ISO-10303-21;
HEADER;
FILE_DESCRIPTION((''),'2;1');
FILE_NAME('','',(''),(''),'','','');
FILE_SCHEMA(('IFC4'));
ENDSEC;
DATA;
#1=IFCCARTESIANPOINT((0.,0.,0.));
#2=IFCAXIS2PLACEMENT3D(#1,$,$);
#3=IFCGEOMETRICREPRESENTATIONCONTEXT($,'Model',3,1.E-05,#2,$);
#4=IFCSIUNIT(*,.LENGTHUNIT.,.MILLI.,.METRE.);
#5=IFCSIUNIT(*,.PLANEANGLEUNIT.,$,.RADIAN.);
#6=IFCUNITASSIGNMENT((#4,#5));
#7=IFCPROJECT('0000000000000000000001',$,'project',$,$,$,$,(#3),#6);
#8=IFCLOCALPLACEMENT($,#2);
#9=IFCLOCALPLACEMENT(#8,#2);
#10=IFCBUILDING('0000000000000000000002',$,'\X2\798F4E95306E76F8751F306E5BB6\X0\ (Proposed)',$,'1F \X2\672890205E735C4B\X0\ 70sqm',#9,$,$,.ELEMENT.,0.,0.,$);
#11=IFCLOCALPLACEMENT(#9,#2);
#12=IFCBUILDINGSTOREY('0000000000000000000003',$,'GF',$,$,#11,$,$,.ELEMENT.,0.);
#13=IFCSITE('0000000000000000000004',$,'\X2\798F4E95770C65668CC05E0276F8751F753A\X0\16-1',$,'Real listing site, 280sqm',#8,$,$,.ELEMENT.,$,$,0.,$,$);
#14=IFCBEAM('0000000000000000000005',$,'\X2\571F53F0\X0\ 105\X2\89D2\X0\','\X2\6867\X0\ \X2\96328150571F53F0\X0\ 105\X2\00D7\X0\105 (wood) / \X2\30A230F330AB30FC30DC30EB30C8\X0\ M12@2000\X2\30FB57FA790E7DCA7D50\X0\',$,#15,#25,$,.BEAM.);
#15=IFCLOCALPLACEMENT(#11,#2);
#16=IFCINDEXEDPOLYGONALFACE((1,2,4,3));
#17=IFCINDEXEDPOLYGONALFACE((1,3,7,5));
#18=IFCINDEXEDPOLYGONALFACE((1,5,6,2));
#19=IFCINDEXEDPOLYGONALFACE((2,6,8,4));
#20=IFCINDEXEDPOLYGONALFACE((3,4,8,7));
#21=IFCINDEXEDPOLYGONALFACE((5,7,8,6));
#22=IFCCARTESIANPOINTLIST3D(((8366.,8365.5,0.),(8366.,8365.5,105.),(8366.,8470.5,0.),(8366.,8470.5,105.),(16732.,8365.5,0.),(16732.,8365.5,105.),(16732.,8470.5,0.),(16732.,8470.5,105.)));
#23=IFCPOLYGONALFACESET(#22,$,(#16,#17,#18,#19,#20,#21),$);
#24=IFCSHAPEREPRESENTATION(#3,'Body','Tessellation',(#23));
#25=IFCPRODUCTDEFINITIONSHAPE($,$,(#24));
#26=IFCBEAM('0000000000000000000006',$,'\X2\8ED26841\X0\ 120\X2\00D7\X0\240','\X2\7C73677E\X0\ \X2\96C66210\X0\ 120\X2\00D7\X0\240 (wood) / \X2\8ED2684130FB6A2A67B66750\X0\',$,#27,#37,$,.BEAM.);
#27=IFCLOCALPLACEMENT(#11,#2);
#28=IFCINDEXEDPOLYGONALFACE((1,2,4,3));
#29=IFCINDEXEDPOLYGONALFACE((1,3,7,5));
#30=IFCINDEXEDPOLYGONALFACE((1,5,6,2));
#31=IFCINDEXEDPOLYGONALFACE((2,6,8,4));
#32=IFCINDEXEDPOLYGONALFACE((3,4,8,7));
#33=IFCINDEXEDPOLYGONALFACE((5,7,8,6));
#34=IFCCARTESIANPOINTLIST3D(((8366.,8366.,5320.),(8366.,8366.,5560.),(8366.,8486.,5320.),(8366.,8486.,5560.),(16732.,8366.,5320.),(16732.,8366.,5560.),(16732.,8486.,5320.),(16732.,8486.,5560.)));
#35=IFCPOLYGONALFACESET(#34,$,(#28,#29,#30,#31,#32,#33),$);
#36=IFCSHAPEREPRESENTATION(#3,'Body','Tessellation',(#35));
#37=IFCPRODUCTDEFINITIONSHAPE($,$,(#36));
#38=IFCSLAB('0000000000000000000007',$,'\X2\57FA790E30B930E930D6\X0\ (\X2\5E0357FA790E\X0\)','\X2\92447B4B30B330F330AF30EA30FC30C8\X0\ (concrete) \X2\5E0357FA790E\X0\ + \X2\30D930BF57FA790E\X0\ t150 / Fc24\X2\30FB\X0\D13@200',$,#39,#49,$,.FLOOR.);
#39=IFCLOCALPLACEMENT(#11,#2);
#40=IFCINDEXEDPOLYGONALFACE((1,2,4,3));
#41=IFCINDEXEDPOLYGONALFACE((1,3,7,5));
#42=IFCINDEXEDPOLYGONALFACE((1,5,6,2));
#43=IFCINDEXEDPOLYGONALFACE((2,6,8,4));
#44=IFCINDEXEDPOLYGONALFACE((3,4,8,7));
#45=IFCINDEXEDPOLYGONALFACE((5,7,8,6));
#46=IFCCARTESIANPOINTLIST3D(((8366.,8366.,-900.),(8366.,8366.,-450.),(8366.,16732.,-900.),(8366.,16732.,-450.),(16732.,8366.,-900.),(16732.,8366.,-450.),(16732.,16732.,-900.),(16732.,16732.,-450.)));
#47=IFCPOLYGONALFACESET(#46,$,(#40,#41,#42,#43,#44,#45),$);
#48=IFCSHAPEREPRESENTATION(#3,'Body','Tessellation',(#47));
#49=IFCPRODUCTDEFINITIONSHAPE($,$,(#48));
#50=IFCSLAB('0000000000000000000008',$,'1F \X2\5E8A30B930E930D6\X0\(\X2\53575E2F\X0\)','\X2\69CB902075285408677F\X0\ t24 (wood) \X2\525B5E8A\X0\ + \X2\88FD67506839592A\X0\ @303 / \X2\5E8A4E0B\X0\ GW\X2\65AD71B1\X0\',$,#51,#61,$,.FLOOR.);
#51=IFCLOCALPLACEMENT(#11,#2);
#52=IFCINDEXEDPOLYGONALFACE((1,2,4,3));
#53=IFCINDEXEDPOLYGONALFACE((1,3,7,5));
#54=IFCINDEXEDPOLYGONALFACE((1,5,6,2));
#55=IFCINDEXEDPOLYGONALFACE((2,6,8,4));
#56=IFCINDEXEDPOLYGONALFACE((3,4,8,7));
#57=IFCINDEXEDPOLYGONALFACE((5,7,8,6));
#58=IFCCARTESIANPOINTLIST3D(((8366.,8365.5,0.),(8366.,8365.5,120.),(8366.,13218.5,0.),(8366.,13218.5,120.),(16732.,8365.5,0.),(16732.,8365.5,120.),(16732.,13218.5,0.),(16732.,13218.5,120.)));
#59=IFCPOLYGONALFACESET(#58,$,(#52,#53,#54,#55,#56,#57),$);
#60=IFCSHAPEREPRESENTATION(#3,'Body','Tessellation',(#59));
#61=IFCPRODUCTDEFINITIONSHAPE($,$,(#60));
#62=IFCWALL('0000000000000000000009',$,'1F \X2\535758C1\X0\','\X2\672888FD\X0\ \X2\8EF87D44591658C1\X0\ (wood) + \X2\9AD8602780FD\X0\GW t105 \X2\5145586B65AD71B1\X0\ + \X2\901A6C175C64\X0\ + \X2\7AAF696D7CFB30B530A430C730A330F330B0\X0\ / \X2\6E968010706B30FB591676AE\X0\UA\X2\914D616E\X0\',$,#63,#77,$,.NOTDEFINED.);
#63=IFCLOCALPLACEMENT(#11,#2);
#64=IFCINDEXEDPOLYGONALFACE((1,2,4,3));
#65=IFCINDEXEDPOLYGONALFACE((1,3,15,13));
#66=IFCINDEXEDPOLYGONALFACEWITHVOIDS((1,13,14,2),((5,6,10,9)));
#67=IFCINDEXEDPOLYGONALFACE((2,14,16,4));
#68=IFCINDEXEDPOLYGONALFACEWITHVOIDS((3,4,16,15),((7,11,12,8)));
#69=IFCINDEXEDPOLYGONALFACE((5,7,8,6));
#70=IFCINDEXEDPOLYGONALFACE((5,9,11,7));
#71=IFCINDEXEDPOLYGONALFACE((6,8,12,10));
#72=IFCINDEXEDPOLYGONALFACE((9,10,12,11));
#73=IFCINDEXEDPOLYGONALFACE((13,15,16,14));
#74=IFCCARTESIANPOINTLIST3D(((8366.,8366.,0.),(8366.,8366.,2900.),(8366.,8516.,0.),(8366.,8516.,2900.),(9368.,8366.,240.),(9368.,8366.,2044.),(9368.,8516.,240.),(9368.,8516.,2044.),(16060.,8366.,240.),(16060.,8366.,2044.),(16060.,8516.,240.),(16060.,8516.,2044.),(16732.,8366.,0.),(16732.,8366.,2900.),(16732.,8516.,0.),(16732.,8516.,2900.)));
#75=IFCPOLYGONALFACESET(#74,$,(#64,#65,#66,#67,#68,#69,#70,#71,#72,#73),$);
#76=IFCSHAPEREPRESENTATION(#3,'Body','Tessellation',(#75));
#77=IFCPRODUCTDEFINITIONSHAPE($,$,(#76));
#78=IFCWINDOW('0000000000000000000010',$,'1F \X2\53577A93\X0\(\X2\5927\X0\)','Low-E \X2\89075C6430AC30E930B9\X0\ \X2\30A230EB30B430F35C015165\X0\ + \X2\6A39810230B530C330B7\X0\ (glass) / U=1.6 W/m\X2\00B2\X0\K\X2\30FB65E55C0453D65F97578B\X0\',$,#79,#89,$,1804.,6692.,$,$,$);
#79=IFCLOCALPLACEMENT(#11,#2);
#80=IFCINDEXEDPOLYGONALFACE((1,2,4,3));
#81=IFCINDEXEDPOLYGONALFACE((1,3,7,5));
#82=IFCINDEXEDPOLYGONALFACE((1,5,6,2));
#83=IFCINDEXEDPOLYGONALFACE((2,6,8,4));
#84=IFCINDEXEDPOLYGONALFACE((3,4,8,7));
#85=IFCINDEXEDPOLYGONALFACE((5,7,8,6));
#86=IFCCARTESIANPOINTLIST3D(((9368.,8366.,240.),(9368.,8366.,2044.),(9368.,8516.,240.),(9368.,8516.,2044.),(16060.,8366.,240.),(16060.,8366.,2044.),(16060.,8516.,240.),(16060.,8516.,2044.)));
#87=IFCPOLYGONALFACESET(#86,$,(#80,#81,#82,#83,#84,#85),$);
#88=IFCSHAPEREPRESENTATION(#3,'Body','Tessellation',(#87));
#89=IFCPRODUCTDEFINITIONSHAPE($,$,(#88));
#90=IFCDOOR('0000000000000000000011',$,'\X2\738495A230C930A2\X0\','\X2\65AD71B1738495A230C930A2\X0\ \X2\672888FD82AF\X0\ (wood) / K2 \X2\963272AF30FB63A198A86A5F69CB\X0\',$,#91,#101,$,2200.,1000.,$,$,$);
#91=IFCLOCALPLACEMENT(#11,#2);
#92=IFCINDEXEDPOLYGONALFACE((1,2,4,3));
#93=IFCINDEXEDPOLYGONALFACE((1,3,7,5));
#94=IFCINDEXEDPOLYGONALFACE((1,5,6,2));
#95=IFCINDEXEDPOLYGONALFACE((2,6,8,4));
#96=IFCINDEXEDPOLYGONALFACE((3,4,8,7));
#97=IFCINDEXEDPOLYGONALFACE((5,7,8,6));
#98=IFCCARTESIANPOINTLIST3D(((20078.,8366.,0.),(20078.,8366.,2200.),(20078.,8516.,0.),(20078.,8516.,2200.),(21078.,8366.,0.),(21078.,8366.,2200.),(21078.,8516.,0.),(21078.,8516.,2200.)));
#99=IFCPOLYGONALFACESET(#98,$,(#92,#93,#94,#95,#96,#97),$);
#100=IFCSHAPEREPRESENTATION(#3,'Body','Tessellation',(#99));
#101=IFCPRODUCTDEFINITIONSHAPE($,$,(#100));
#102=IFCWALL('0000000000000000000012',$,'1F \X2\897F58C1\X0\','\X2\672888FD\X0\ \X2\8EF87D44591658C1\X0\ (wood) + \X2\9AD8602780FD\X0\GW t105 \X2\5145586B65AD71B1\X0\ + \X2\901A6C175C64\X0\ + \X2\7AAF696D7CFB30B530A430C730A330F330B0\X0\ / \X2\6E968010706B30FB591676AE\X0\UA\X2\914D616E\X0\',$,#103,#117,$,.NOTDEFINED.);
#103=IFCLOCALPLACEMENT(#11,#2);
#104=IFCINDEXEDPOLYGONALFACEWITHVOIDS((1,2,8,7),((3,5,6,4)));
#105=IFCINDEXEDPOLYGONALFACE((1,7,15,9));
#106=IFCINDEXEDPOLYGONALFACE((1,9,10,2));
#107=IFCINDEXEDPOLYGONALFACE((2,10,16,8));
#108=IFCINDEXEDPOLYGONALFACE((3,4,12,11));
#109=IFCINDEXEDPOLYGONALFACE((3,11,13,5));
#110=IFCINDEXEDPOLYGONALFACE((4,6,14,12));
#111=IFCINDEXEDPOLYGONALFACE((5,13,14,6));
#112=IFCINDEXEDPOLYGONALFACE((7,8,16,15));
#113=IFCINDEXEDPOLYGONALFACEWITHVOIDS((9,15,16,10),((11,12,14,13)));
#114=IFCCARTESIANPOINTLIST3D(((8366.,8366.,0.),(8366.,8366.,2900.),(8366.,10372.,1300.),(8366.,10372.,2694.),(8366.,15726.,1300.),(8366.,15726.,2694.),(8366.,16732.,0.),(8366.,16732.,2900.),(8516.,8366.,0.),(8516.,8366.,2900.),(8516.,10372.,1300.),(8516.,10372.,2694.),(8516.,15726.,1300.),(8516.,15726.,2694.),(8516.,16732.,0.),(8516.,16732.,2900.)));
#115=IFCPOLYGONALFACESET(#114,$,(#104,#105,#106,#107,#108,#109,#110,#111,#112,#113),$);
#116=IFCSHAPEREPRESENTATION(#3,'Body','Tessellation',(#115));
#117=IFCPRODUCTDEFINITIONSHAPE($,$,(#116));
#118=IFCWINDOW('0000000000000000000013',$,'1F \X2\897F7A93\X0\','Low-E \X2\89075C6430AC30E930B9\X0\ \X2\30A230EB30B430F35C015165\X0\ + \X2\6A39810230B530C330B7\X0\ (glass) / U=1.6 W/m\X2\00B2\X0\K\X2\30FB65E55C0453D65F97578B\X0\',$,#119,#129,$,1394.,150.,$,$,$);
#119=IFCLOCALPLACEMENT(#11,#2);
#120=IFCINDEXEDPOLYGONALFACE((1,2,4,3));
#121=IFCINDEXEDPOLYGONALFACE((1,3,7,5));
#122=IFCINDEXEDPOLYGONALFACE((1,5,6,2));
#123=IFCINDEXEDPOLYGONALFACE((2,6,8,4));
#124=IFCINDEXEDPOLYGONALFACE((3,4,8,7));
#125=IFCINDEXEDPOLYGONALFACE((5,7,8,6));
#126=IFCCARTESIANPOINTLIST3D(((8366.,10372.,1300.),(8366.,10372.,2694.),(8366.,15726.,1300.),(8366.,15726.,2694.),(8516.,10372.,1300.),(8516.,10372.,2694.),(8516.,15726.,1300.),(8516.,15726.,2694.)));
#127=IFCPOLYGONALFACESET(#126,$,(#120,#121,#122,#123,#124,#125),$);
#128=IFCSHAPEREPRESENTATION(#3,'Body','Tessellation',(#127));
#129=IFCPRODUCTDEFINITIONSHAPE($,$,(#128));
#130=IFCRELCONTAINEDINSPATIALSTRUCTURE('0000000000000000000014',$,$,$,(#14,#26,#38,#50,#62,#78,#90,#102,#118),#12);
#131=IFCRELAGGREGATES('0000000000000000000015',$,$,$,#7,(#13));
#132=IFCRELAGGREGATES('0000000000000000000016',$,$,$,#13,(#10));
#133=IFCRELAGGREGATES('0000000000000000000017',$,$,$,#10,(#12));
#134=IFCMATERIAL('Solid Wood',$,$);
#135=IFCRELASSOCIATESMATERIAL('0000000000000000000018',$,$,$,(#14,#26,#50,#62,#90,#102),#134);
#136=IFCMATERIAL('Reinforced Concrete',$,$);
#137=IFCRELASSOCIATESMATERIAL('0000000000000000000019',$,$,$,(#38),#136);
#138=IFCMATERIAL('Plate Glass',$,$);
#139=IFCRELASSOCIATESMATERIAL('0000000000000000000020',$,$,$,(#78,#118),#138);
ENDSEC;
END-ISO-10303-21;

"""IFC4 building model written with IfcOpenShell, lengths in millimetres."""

from ifc_helpers import new_model, si_unit, frame, frame_2d, origin, place, context, project, spatial, rectangle, extrude, material, element, fill, save


model = new_model("IFC4")

# Units and contexts
model_context = context("Model", 3, precision=1e-05, world=origin())
ifc_project = project(units=[si_unit("LENGTHUNIT", "METRE", prefix="MILLI"), si_unit("PLANEANGLEUNIT", "RADIAN")], contexts=[model_context])

# Site, building, storey
site_placement = place(None, origin())
site = spatial("IfcSite", under=ifc_project, at=site_placement, Name="福井県敦賀市相生町16-1", ObjectType="Real listing site, 280sqm", CompositionType="ELEMENT", RefElevation=0.0)
building_placement = place(site_placement, origin())
building = spatial("IfcBuilding", under=site, at=building_placement, Name="福井の相生の家 (Proposed)", ObjectType="1F 木造平屋 70sqm", CompositionType="ELEMENT", ElevationOfRefHeight=0.0, ElevationOfTerrain=0.0)
storey_placement = place(building_placement, origin())
storey = spatial("IfcBuildingStorey", under=building, at=storey_placement, Name="GF", CompositionType="ELEMENT", Elevation=0.0)

# Shared definitions
ifc_material_1 = material(Name="Solid Wood")

# Beams
beam_1_placement = place(storey_placement, frame((4183.0, 4183.0, 0.0)))
element("IfcBeam", 1, at=beam_1_placement, inside=storey, material=ifc_material_1, Name="土台 105角", Description="桧 防腐土台 105×105 (wood) / アンカーボルト M12@2000・基礎緊結", PredefinedType="BEAM", context=model_context, shape_type="SweptSolid", body=[
    extrude(rectangle(XDim=8366.0, YDim=105.0, at=frame_2d((4183.0, 52.0))), frame((4183.0, 4183.0, 0.0)), (0.0, 0.0, 1.0), 105.0),
])
beam_2_placement = place(storey_placement, frame((4183.0, 4183.0, 2660.0)))
element("IfcBeam", 2, at=beam_2_placement, inside=storey, material=ifc_material_1, Name="軒桁 120×240", Description="米松 集成 120×240 (wood) / 軒桁・横架材", PredefinedType="BEAM", context=model_context, shape_type="SweptSolid", body=[
    extrude(rectangle(XDim=8366.0, YDim=120.0, at=frame_2d((4183.0, 60.0))), frame((4183.0, 4183.0, 2660.0)), (0.0, 0.0, 1.0), 240.0),
])

# Slabs
ifc_material_2 = material(Name="Reinforced Concrete")
slab_1_placement = place(storey_placement, frame((4183.0, 4183.0, -450.0)))
element("IfcSlab", 3, at=slab_1_placement, inside=storey, material=ifc_material_2, Name="基礎スラブ (布基礎)", Description="鉄筋コンクリート (concrete) 布基礎 + ベタ基礎 t150 / Fc24・D13@200", PredefinedType="FLOOR", context=model_context, shape_type="SweptSolid", body=[
    extrude(rectangle(XDim=8366.0, YDim=8366.0, at=frame_2d((4183.0, 4183.0))), frame((4183.0, 4183.0, -450.0)), (0.0, 0.0, 1.0), 450.0),
])
slab_2_placement = place(storey_placement, frame((4183.0, 4183.0, 0.0)))
element("IfcSlab", 4, at=slab_2_placement, inside=storey, material=ifc_material_1, Name="1F 床スラブ(南帯)", Description="構造用合板 t24 (wood) 剛床 + 製材根太 @303 / 床下 GW断熱", PredefinedType="FLOOR", context=model_context, shape_type="SweptSolid", body=[
    extrude(rectangle(XDim=8366.0, YDim=4853.0, at=frame_2d((4183.0, 2426.0))), frame((4183.0, 4183.0, 0.0)), (0.0, 0.0, 1.0), 120.0),
])

# Wall, openings, window, door
wall_1_placement = place(storey_placement, frame((4183.0, 4183.0, 0.0)))
wall_1 = element("IfcWall", 5, at=wall_1_placement, inside=storey, material=ifc_material_1, Name="1F 南壁", Description="木製 軸組外壁 (wood) + 高性能GW t105 充填断熱 + 通気層 + 窯業系サイディング / 準耐火・外皮UA配慮", PredefinedType="NOTDEFINED", context=model_context, shape_type="SweptSolid", body=[
    extrude(rectangle(XDim=8366.0, YDim=150.0, at=frame_2d((4183.0, 75.0))), frame((4183.0, 4183.0, 0.0)), (0.0, 0.0, 1.0), 2900.0),
])
opening_1_placement = place(storey_placement, frame((4684.0, 4183.0, 120.0)))
opening_1 = element("IfcOpeningElement", 6, at=opening_1_placement, cuts=wall_1, PredefinedType="NOTDEFINED", context=model_context, shape_type="SweptSolid", body=[
    extrude(rectangle(XDim=6692.0, YDim=150.0, at=frame_2d((3346.0, 75.0))), frame((4684.0, 4183.0, 120.0)), (0.0, 0.0, 1.0), 1804.0),
])
opening_2_placement = place(storey_placement, frame((10039.0, 4183.0, 0.0)))
opening_2 = element("IfcOpeningElement", 7, at=opening_2_placement, cuts=wall_1, PredefinedType="NOTDEFINED", context=model_context, shape_type="SweptSolid", body=[
    extrude(rectangle(XDim=1000.0, YDim=150.0, at=frame_2d((500.0, 75.0))), frame((10039.0, 4183.0, 0.0)), (0.0, 0.0, 1.0), 2200.0),
])
ifc_material_3 = material(Name="Plate Glass")
window_1_placement = place(storey_placement, frame((4684.0, 4183.0, 120.0)))
window_1 = element("IfcWindow", 8, at=window_1_placement, inside=storey, material=ifc_material_3, Name="1F 南窓(大)", Description="Low-E 複層ガラス アルゴン封入 + 樹脂サッシ (glass) / U=1.6 W/m²K・日射取得型", OverallHeight=1804.0, OverallWidth=6692.0, context=model_context, shape_type="SweptSolid", body=[
    extrude(rectangle(XDim=6692.0, YDim=150.0, at=frame_2d((3346.0, 75.0))), frame((4684.0, 4183.0, 120.0)), (0.0, 0.0, 1.0), 1804.0),
])
fill(opening_1, window_1)
door_placement = place(storey_placement, frame((10039.0, 4183.0, 0.0)))
door = element("IfcDoor", 9, at=door_placement, inside=storey, material=ifc_material_1, Name="玄関ドア", Description="断熱玄関ドア 木製芯 (wood) / K2 防犯・採風機構", OverallHeight=2200.0, OverallWidth=1000.0, context=model_context, shape_type="SweptSolid", body=[
    extrude(rectangle(XDim=1000.0, YDim=150.0, at=frame_2d((500.0, 75.0))), frame((10039.0, 4183.0, 0.0)), (0.0, 0.0, 1.0), 2200.0),
])
fill(opening_2, door)

# Wall, opening, window
wall_2_placement = place(storey_placement, frame((4183.0, 4183.0, 0.0)))
wall_2 = element("IfcWall", 10, at=wall_2_placement, inside=storey, material=ifc_material_1, Name="1F 西壁", Description="木製 軸組外壁 (wood) + 高性能GW t105 充填断熱 + 通気層 + 窯業系サイディング / 準耐火・外皮UA配慮", PredefinedType="NOTDEFINED", context=model_context, shape_type="SweptSolid", body=[
    extrude(rectangle(XDim=150.0, YDim=8366.0, at=frame_2d((75.0, 4183.0))), frame((4183.0, 4183.0, 0.0)), (0.0, 0.0, 1.0), 2900.0),
])
opening_3_placement = place(storey_placement, frame((4183.0, 5186.0, 650.0)))
opening_3 = element("IfcOpeningElement", 11, at=opening_3_placement, cuts=wall_2, PredefinedType="NOTDEFINED", context=model_context, shape_type="SweptSolid", body=[
    extrude(rectangle(XDim=150.0, YDim=5354.0, at=frame_2d((75.0, 2677.0))), frame((4183.0, 5186.0, 650.0)), (0.0, 0.0, 1.0), 1394.0),
])
window_2_placement = place(storey_placement, frame((4183.0, 5186.0, 650.0)))
window_2 = element("IfcWindow", 12, at=window_2_placement, inside=storey, material=ifc_material_3, Name="1F 西窓", Description="Low-E 複層ガラス アルゴン封入 + 樹脂サッシ (glass) / U=1.6 W/m²K・日射取得型", OverallHeight=1394.0, OverallWidth=150.0, context=model_context, shape_type="SweptSolid", body=[
    extrude(rectangle(XDim=150.0, YDim=5354.0, at=frame_2d((75.0, 2677.0))), frame((4183.0, 5186.0, 650.0)), (0.0, 0.0, 1.0), 1394.0),
])
fill(opening_3, window_2)

save(model, "model.ifc")
